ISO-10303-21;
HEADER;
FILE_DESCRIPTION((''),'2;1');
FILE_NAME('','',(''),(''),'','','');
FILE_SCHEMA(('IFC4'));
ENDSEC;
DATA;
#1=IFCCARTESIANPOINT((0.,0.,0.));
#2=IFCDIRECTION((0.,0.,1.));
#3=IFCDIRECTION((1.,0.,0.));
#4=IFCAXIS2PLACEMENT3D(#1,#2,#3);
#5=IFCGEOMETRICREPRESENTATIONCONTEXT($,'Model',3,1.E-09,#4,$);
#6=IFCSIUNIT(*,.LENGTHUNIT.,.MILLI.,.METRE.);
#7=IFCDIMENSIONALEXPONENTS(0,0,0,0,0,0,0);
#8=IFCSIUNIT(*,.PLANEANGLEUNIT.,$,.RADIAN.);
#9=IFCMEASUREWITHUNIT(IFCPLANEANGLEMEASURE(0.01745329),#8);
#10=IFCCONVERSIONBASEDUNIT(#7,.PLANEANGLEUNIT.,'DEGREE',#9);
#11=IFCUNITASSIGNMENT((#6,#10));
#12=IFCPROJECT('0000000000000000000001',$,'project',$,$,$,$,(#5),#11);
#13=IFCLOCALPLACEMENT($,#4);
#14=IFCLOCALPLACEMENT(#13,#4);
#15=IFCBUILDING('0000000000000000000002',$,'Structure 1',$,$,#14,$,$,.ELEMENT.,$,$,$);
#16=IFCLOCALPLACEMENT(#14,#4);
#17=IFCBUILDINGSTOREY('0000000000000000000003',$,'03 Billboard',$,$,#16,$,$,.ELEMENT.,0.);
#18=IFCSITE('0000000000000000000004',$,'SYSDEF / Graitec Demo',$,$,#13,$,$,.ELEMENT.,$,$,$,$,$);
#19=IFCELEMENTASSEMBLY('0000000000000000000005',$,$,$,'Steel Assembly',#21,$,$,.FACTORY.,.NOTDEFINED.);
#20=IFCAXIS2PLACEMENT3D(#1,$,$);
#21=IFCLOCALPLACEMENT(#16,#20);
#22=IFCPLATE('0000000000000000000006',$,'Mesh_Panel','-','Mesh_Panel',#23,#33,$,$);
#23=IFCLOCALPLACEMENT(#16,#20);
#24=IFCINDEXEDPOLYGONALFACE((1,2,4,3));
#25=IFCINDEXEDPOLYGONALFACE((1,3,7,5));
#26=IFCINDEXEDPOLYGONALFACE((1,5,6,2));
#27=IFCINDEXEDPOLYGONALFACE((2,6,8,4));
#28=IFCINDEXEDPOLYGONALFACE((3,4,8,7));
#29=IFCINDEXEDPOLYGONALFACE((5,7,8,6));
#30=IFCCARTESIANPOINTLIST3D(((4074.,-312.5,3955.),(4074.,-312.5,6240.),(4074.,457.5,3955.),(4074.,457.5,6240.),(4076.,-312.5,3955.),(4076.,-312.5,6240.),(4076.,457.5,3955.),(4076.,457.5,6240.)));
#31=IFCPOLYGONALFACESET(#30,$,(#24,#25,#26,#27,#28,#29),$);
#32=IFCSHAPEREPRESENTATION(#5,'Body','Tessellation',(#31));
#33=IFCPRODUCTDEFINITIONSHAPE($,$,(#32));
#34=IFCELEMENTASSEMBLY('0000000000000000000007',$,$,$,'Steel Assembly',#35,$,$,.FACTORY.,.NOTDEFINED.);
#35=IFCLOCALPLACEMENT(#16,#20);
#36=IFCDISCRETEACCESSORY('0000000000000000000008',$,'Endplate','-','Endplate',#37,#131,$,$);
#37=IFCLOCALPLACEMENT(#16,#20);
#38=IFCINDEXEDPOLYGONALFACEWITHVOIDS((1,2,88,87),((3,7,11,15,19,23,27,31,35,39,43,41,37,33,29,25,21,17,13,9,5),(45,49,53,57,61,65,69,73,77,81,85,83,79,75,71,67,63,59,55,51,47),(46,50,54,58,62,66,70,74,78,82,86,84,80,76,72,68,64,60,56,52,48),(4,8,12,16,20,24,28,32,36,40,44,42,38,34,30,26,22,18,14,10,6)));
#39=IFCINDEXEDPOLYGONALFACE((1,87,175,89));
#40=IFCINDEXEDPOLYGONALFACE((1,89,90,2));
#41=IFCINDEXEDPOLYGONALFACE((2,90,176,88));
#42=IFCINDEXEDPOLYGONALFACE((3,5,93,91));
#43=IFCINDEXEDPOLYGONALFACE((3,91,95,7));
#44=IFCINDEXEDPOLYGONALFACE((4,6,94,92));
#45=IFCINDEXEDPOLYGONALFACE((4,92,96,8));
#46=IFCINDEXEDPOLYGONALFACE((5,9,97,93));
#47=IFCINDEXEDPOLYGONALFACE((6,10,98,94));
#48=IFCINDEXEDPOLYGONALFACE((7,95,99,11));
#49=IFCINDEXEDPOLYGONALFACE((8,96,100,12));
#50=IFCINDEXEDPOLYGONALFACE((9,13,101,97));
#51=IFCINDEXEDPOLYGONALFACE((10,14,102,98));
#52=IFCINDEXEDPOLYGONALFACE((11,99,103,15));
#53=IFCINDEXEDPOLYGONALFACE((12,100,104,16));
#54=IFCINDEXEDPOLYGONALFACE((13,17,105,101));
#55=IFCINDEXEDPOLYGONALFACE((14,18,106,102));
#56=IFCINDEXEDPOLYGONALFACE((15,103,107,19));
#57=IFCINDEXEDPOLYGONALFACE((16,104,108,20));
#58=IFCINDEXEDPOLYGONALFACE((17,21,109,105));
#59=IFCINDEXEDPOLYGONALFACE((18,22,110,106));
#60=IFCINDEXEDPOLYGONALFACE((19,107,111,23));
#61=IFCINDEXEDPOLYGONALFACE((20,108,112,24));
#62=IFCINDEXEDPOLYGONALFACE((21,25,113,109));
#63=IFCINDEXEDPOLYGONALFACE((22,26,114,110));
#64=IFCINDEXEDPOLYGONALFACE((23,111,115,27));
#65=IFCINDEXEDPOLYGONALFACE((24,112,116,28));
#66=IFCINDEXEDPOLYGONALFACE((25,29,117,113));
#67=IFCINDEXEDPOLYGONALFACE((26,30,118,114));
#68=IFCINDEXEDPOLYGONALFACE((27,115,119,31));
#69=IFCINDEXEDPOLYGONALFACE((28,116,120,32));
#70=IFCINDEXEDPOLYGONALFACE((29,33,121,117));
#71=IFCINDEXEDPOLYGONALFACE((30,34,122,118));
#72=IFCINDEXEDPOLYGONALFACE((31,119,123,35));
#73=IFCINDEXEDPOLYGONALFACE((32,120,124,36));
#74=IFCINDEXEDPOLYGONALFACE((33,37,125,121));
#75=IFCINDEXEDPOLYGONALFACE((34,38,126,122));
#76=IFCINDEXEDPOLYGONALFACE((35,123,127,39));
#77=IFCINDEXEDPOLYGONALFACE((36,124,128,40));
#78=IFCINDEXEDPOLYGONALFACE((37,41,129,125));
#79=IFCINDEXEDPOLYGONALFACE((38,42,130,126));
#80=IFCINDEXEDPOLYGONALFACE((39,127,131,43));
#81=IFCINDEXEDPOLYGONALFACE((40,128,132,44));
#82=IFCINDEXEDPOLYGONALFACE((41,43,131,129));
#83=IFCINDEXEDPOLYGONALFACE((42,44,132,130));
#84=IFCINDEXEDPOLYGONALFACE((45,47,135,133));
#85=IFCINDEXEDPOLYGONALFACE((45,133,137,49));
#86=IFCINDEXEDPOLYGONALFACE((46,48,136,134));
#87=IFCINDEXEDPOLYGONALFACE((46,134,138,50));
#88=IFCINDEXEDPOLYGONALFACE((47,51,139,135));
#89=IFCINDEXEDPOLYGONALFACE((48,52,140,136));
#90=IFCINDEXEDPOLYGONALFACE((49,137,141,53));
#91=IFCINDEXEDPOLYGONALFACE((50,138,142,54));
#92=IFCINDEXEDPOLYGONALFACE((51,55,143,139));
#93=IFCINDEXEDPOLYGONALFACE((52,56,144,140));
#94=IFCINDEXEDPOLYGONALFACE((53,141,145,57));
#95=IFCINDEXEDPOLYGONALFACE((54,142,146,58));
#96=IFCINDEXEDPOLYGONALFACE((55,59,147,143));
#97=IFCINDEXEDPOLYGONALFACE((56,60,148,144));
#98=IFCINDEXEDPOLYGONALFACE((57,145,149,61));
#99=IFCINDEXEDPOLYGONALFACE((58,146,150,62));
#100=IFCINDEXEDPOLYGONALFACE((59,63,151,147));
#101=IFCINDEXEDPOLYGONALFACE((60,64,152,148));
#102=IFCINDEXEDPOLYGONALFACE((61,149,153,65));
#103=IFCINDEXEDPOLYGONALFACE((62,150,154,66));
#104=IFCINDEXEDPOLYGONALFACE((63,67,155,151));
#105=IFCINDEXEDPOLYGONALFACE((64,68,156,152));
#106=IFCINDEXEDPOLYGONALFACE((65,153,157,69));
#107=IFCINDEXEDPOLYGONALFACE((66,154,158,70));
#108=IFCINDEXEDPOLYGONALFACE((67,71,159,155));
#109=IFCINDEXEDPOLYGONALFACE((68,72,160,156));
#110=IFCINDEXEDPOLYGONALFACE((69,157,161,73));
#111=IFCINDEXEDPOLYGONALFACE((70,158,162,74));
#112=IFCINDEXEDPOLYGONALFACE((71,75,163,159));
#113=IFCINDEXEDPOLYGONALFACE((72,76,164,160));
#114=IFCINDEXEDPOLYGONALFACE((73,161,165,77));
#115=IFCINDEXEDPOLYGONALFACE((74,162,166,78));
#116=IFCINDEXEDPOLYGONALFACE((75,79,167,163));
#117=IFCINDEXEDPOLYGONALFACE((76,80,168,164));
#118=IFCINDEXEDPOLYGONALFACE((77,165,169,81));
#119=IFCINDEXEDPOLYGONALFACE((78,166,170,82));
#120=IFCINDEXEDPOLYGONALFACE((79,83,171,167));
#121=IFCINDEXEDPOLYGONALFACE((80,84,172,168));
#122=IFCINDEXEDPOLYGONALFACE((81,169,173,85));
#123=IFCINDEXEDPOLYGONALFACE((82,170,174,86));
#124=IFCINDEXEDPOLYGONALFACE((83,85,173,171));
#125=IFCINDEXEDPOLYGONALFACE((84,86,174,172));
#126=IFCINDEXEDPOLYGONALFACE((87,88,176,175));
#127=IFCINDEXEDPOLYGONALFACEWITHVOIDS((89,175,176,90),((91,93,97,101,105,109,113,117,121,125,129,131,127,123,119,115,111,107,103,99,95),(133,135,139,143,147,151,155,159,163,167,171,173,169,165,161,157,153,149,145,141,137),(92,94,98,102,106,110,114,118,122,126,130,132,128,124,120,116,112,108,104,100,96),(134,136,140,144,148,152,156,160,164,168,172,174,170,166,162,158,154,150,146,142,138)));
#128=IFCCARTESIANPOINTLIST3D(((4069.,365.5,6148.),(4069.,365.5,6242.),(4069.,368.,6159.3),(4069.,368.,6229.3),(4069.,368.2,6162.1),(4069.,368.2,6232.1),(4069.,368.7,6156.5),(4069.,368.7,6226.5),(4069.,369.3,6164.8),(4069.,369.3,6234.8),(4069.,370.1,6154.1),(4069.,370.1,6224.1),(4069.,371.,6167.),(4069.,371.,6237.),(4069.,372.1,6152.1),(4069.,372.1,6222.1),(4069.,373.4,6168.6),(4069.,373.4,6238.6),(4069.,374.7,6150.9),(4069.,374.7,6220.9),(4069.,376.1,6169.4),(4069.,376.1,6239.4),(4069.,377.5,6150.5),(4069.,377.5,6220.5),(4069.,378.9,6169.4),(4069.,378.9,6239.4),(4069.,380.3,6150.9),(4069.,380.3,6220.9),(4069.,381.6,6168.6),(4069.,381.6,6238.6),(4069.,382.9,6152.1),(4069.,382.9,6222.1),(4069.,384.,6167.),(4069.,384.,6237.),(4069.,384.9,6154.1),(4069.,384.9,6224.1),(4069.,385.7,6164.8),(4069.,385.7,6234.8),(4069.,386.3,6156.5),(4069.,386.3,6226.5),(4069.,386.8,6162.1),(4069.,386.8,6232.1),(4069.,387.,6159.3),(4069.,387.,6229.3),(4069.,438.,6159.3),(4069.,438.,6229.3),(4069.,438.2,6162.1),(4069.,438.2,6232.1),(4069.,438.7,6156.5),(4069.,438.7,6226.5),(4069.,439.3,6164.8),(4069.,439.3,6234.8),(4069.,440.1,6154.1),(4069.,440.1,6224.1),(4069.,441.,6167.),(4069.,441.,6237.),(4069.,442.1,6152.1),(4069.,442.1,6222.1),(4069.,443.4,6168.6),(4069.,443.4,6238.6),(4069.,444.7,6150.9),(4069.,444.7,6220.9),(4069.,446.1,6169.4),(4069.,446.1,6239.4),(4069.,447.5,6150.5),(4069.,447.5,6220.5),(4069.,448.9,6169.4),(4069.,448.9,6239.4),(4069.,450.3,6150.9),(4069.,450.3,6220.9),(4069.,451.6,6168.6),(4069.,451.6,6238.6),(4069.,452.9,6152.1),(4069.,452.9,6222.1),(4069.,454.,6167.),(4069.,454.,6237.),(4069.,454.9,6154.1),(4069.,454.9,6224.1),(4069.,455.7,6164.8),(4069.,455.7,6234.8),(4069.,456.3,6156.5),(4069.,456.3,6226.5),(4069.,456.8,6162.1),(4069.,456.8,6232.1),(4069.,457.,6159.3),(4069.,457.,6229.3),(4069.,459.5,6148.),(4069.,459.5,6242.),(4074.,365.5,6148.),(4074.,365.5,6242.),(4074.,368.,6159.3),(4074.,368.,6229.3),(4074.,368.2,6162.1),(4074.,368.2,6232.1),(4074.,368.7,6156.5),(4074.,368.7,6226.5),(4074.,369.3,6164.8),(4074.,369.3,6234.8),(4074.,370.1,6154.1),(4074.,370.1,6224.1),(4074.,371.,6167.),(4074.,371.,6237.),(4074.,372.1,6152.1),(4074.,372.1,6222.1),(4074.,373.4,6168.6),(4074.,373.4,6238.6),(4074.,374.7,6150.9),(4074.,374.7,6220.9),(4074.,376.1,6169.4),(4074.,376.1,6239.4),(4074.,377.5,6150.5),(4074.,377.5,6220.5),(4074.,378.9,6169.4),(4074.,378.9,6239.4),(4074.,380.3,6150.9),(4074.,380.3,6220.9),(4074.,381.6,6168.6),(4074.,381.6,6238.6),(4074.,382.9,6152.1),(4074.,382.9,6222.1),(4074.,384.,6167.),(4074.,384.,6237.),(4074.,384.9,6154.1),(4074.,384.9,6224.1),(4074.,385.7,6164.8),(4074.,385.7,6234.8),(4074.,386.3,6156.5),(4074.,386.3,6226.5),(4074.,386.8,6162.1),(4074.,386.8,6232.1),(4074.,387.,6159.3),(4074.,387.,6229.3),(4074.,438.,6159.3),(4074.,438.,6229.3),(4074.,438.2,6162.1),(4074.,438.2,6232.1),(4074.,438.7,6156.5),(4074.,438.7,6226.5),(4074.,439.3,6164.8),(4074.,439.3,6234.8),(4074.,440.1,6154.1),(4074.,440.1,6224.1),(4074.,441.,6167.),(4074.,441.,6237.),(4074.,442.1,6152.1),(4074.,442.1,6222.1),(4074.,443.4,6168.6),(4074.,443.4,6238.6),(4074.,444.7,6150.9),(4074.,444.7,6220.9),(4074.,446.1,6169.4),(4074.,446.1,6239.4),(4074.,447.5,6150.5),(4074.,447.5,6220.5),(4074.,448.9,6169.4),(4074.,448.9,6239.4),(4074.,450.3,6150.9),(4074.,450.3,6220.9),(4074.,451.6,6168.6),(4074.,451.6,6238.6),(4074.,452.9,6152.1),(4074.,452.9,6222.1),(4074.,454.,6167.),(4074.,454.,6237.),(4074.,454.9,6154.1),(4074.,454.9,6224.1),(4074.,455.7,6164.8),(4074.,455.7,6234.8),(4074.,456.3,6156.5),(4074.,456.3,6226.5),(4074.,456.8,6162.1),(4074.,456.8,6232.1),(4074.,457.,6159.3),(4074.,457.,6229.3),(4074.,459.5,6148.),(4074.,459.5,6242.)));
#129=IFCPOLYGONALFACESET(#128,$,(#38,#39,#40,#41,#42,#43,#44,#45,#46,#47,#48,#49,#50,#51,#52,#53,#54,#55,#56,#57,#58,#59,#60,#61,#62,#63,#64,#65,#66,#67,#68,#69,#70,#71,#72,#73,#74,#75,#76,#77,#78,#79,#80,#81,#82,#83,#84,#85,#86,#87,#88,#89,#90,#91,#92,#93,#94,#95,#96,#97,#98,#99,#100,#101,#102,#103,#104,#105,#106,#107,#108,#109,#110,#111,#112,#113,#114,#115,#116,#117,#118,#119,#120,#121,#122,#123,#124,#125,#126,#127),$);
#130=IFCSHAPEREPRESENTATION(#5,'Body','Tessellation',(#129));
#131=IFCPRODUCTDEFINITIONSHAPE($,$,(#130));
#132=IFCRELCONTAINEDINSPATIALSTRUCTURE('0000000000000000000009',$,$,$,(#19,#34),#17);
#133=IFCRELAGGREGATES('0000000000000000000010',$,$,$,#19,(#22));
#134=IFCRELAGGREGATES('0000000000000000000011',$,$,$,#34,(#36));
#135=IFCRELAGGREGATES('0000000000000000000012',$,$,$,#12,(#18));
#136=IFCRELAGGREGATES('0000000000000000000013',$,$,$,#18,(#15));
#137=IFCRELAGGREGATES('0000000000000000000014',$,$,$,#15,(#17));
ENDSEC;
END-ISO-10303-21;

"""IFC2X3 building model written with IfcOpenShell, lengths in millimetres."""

from ifc_helpers import new_model, entity, si_unit, converted_unit, frame, frame_2d, origin, origin_with_axes, place, context, project, spatial, polyline, circle, outline, extrude, element, aggregate, save


model = new_model("IFC2X3")

# Units and contexts
model_context = context("Model", 3, precision=1e-09, world=origin_with_axes())
ifc_project = project(units=[si_unit("LENGTHUNIT", "METRE", prefix="MILLI"), converted_unit("PLANEANGLEUNIT", "DEGREE", entity("IfcPlaneAngleMeasure", 0.01745329), si_unit("PLANEANGLEUNIT", "RADIAN"), dimensions=[0, 0, 0, 0, 0, 0, 0])], contexts=[model_context])

# Site, building, storey
site_placement = place(None, origin_with_axes())
site = spatial("IfcSite", under=ifc_project, at=site_placement, Name="SYSDEF / Graitec Demo", CompositionType="ELEMENT")
building_placement = place(site_placement, origin_with_axes())
building = spatial("IfcBuilding", under=site, at=building_placement, Name="Structure 1", CompositionType="ELEMENT")
storey_placement = place(building_placement, origin_with_axes())
storey = spatial("IfcBuildingStorey", under=building, at=storey_placement, Name="03 Billboard", CompositionType="ELEMENT", Elevation=0.0)

# Element assembly, plate
assembly_1_placement = place(None, frame((4076.0, 72.5, 5097.5), z_axis=(-1.0, 0.0, -0.000006), x_axis=(0.0, 1.0, 0.000001)))
assembly_1 = element("IfcElementAssembly", 1, at=assembly_1_placement, inside=storey, ObjectType="Steel Assembly", AssemblyPlace="FACTORY", PredefinedType="NOTDEFINED")
plate_1_placement = place(assembly_1_placement, origin_with_axes())
plate_1 = element("IfcPlate", 2, at=plate_1_placement, Name="Mesh_Panel", Description="-", ObjectType="Mesh_Panel", context=model_context, shape_type="SweptSolid", body=[
    extrude(outline(polyline([(-385.0, -1142.5), (385.0, -1142.5), (385.0, 1142.5), (-385.0, 1142.5), (-385.0, -1142.5)])), origin_with_axes(), (0.0, 0.0, 1.0), 2.0),
])
aggregate(assembly_1, [plate_1])

# Element assembly, discrete accessory, openings
assembly_2_placement = place(None, frame((-4239.1, -387.5, 4000.0), z_axis=(-1.0, 0.0, 0.0), x_axis=(0.0, 0.0, 1.0)))
assembly_2 = element("IfcElementAssembly", 3, at=assembly_2_placement, inside=storey, ObjectType="Steel Assembly", AssemblyPlace="FACTORY", PredefinedType="NOTDEFINED")
discrete_accessory_1_placement = place(assembly_2_placement, frame((2242.0, 847.0, -8308.1), z_axis=(0.0, 0.0, -1.0), x_axis=(0.0, -1.0, 0.0)))
discrete_accessory_1 = element("IfcDiscreteAccessory", 4, at=discrete_accessory_1_placement, Name="Endplate", Description="-", ObjectType="Endplate", context=model_context, shape_type="SweptSolid", body=[
    extrude(outline(polyline([(0.0, 0.0), (94.0, 0.0), (94.0, 94.0), (0.0, 94.0), (0.0, 0.0)])), origin_with_axes(), (0.0, 0.0, 1.0), 5.0),
])
opening_1_placement = place(discrete_accessory_1_placement, frame((47.0, 47.0, -0.5), z_axis=(0.0, 0.0, 1.0), x_axis=(0.0, 1.0, 0.0)))
element("IfcOpeningElement", 5, at=opening_1_placement, cuts=discrete_accessory_1, ObjectType="Opening", context=model_context, shape_type="SweptSolid", body=[
    extrude(circle(Radius=9.5, at=frame_2d((35.0, 35.0), x_axis=(1.0, 0.0))), origin(), (0.0, 0.0, 1.0), 6.0),
])
opening_2_placement = place(discrete_accessory_1_placement, frame((47.0, 47.0, -0.5), z_axis=(0.0, 0.0, 1.0), x_axis=(0.0, 1.0, 0.0)))
element("IfcOpeningElement", 6, at=opening_2_placement, cuts=discrete_accessory_1, ObjectType="Opening", context=model_context, shape_type="SweptSolid", body=[
    extrude(circle(Radius=9.5, at=frame_2d((-35.0, 35.0), x_axis=(1.0, 0.0))), origin(), (0.0, 0.0, 1.0), 6.0),
])
opening_3_placement = place(discrete_accessory_1_placement, frame((47.0, 47.0, -0.5), z_axis=(0.0, 0.0, 1.0), x_axis=(0.0, 1.0, 0.0)))
element("IfcOpeningElement", 7, at=opening_3_placement, cuts=discrete_accessory_1, ObjectType="Opening", context=model_context, shape_type="SweptSolid", body=[
    extrude(circle(Radius=9.5, at=frame_2d((35.0, -35.0), x_axis=(1.0, 0.0))), origin(), (0.0, 0.0, 1.0), 6.0),
])
opening_4_placement = place(discrete_accessory_1_placement, frame((47.0, 47.0, -0.5), z_axis=(0.0, 0.0, 1.0), x_axis=(0.0, 1.0, 0.0)))
element("IfcOpeningElement", 8, at=opening_4_placement, cuts=discrete_accessory_1, ObjectType="Opening", context=model_context, shape_type="SweptSolid", body=[
    extrude(circle(Radius=9.5, at=frame_2d((-35.0, -35.0), x_axis=(1.0, 0.0))), origin(), (0.0, 0.0, 1.0), 6.0),
])
aggregate(assembly_2, [discrete_accessory_1])

save(model, "model.ifc")
